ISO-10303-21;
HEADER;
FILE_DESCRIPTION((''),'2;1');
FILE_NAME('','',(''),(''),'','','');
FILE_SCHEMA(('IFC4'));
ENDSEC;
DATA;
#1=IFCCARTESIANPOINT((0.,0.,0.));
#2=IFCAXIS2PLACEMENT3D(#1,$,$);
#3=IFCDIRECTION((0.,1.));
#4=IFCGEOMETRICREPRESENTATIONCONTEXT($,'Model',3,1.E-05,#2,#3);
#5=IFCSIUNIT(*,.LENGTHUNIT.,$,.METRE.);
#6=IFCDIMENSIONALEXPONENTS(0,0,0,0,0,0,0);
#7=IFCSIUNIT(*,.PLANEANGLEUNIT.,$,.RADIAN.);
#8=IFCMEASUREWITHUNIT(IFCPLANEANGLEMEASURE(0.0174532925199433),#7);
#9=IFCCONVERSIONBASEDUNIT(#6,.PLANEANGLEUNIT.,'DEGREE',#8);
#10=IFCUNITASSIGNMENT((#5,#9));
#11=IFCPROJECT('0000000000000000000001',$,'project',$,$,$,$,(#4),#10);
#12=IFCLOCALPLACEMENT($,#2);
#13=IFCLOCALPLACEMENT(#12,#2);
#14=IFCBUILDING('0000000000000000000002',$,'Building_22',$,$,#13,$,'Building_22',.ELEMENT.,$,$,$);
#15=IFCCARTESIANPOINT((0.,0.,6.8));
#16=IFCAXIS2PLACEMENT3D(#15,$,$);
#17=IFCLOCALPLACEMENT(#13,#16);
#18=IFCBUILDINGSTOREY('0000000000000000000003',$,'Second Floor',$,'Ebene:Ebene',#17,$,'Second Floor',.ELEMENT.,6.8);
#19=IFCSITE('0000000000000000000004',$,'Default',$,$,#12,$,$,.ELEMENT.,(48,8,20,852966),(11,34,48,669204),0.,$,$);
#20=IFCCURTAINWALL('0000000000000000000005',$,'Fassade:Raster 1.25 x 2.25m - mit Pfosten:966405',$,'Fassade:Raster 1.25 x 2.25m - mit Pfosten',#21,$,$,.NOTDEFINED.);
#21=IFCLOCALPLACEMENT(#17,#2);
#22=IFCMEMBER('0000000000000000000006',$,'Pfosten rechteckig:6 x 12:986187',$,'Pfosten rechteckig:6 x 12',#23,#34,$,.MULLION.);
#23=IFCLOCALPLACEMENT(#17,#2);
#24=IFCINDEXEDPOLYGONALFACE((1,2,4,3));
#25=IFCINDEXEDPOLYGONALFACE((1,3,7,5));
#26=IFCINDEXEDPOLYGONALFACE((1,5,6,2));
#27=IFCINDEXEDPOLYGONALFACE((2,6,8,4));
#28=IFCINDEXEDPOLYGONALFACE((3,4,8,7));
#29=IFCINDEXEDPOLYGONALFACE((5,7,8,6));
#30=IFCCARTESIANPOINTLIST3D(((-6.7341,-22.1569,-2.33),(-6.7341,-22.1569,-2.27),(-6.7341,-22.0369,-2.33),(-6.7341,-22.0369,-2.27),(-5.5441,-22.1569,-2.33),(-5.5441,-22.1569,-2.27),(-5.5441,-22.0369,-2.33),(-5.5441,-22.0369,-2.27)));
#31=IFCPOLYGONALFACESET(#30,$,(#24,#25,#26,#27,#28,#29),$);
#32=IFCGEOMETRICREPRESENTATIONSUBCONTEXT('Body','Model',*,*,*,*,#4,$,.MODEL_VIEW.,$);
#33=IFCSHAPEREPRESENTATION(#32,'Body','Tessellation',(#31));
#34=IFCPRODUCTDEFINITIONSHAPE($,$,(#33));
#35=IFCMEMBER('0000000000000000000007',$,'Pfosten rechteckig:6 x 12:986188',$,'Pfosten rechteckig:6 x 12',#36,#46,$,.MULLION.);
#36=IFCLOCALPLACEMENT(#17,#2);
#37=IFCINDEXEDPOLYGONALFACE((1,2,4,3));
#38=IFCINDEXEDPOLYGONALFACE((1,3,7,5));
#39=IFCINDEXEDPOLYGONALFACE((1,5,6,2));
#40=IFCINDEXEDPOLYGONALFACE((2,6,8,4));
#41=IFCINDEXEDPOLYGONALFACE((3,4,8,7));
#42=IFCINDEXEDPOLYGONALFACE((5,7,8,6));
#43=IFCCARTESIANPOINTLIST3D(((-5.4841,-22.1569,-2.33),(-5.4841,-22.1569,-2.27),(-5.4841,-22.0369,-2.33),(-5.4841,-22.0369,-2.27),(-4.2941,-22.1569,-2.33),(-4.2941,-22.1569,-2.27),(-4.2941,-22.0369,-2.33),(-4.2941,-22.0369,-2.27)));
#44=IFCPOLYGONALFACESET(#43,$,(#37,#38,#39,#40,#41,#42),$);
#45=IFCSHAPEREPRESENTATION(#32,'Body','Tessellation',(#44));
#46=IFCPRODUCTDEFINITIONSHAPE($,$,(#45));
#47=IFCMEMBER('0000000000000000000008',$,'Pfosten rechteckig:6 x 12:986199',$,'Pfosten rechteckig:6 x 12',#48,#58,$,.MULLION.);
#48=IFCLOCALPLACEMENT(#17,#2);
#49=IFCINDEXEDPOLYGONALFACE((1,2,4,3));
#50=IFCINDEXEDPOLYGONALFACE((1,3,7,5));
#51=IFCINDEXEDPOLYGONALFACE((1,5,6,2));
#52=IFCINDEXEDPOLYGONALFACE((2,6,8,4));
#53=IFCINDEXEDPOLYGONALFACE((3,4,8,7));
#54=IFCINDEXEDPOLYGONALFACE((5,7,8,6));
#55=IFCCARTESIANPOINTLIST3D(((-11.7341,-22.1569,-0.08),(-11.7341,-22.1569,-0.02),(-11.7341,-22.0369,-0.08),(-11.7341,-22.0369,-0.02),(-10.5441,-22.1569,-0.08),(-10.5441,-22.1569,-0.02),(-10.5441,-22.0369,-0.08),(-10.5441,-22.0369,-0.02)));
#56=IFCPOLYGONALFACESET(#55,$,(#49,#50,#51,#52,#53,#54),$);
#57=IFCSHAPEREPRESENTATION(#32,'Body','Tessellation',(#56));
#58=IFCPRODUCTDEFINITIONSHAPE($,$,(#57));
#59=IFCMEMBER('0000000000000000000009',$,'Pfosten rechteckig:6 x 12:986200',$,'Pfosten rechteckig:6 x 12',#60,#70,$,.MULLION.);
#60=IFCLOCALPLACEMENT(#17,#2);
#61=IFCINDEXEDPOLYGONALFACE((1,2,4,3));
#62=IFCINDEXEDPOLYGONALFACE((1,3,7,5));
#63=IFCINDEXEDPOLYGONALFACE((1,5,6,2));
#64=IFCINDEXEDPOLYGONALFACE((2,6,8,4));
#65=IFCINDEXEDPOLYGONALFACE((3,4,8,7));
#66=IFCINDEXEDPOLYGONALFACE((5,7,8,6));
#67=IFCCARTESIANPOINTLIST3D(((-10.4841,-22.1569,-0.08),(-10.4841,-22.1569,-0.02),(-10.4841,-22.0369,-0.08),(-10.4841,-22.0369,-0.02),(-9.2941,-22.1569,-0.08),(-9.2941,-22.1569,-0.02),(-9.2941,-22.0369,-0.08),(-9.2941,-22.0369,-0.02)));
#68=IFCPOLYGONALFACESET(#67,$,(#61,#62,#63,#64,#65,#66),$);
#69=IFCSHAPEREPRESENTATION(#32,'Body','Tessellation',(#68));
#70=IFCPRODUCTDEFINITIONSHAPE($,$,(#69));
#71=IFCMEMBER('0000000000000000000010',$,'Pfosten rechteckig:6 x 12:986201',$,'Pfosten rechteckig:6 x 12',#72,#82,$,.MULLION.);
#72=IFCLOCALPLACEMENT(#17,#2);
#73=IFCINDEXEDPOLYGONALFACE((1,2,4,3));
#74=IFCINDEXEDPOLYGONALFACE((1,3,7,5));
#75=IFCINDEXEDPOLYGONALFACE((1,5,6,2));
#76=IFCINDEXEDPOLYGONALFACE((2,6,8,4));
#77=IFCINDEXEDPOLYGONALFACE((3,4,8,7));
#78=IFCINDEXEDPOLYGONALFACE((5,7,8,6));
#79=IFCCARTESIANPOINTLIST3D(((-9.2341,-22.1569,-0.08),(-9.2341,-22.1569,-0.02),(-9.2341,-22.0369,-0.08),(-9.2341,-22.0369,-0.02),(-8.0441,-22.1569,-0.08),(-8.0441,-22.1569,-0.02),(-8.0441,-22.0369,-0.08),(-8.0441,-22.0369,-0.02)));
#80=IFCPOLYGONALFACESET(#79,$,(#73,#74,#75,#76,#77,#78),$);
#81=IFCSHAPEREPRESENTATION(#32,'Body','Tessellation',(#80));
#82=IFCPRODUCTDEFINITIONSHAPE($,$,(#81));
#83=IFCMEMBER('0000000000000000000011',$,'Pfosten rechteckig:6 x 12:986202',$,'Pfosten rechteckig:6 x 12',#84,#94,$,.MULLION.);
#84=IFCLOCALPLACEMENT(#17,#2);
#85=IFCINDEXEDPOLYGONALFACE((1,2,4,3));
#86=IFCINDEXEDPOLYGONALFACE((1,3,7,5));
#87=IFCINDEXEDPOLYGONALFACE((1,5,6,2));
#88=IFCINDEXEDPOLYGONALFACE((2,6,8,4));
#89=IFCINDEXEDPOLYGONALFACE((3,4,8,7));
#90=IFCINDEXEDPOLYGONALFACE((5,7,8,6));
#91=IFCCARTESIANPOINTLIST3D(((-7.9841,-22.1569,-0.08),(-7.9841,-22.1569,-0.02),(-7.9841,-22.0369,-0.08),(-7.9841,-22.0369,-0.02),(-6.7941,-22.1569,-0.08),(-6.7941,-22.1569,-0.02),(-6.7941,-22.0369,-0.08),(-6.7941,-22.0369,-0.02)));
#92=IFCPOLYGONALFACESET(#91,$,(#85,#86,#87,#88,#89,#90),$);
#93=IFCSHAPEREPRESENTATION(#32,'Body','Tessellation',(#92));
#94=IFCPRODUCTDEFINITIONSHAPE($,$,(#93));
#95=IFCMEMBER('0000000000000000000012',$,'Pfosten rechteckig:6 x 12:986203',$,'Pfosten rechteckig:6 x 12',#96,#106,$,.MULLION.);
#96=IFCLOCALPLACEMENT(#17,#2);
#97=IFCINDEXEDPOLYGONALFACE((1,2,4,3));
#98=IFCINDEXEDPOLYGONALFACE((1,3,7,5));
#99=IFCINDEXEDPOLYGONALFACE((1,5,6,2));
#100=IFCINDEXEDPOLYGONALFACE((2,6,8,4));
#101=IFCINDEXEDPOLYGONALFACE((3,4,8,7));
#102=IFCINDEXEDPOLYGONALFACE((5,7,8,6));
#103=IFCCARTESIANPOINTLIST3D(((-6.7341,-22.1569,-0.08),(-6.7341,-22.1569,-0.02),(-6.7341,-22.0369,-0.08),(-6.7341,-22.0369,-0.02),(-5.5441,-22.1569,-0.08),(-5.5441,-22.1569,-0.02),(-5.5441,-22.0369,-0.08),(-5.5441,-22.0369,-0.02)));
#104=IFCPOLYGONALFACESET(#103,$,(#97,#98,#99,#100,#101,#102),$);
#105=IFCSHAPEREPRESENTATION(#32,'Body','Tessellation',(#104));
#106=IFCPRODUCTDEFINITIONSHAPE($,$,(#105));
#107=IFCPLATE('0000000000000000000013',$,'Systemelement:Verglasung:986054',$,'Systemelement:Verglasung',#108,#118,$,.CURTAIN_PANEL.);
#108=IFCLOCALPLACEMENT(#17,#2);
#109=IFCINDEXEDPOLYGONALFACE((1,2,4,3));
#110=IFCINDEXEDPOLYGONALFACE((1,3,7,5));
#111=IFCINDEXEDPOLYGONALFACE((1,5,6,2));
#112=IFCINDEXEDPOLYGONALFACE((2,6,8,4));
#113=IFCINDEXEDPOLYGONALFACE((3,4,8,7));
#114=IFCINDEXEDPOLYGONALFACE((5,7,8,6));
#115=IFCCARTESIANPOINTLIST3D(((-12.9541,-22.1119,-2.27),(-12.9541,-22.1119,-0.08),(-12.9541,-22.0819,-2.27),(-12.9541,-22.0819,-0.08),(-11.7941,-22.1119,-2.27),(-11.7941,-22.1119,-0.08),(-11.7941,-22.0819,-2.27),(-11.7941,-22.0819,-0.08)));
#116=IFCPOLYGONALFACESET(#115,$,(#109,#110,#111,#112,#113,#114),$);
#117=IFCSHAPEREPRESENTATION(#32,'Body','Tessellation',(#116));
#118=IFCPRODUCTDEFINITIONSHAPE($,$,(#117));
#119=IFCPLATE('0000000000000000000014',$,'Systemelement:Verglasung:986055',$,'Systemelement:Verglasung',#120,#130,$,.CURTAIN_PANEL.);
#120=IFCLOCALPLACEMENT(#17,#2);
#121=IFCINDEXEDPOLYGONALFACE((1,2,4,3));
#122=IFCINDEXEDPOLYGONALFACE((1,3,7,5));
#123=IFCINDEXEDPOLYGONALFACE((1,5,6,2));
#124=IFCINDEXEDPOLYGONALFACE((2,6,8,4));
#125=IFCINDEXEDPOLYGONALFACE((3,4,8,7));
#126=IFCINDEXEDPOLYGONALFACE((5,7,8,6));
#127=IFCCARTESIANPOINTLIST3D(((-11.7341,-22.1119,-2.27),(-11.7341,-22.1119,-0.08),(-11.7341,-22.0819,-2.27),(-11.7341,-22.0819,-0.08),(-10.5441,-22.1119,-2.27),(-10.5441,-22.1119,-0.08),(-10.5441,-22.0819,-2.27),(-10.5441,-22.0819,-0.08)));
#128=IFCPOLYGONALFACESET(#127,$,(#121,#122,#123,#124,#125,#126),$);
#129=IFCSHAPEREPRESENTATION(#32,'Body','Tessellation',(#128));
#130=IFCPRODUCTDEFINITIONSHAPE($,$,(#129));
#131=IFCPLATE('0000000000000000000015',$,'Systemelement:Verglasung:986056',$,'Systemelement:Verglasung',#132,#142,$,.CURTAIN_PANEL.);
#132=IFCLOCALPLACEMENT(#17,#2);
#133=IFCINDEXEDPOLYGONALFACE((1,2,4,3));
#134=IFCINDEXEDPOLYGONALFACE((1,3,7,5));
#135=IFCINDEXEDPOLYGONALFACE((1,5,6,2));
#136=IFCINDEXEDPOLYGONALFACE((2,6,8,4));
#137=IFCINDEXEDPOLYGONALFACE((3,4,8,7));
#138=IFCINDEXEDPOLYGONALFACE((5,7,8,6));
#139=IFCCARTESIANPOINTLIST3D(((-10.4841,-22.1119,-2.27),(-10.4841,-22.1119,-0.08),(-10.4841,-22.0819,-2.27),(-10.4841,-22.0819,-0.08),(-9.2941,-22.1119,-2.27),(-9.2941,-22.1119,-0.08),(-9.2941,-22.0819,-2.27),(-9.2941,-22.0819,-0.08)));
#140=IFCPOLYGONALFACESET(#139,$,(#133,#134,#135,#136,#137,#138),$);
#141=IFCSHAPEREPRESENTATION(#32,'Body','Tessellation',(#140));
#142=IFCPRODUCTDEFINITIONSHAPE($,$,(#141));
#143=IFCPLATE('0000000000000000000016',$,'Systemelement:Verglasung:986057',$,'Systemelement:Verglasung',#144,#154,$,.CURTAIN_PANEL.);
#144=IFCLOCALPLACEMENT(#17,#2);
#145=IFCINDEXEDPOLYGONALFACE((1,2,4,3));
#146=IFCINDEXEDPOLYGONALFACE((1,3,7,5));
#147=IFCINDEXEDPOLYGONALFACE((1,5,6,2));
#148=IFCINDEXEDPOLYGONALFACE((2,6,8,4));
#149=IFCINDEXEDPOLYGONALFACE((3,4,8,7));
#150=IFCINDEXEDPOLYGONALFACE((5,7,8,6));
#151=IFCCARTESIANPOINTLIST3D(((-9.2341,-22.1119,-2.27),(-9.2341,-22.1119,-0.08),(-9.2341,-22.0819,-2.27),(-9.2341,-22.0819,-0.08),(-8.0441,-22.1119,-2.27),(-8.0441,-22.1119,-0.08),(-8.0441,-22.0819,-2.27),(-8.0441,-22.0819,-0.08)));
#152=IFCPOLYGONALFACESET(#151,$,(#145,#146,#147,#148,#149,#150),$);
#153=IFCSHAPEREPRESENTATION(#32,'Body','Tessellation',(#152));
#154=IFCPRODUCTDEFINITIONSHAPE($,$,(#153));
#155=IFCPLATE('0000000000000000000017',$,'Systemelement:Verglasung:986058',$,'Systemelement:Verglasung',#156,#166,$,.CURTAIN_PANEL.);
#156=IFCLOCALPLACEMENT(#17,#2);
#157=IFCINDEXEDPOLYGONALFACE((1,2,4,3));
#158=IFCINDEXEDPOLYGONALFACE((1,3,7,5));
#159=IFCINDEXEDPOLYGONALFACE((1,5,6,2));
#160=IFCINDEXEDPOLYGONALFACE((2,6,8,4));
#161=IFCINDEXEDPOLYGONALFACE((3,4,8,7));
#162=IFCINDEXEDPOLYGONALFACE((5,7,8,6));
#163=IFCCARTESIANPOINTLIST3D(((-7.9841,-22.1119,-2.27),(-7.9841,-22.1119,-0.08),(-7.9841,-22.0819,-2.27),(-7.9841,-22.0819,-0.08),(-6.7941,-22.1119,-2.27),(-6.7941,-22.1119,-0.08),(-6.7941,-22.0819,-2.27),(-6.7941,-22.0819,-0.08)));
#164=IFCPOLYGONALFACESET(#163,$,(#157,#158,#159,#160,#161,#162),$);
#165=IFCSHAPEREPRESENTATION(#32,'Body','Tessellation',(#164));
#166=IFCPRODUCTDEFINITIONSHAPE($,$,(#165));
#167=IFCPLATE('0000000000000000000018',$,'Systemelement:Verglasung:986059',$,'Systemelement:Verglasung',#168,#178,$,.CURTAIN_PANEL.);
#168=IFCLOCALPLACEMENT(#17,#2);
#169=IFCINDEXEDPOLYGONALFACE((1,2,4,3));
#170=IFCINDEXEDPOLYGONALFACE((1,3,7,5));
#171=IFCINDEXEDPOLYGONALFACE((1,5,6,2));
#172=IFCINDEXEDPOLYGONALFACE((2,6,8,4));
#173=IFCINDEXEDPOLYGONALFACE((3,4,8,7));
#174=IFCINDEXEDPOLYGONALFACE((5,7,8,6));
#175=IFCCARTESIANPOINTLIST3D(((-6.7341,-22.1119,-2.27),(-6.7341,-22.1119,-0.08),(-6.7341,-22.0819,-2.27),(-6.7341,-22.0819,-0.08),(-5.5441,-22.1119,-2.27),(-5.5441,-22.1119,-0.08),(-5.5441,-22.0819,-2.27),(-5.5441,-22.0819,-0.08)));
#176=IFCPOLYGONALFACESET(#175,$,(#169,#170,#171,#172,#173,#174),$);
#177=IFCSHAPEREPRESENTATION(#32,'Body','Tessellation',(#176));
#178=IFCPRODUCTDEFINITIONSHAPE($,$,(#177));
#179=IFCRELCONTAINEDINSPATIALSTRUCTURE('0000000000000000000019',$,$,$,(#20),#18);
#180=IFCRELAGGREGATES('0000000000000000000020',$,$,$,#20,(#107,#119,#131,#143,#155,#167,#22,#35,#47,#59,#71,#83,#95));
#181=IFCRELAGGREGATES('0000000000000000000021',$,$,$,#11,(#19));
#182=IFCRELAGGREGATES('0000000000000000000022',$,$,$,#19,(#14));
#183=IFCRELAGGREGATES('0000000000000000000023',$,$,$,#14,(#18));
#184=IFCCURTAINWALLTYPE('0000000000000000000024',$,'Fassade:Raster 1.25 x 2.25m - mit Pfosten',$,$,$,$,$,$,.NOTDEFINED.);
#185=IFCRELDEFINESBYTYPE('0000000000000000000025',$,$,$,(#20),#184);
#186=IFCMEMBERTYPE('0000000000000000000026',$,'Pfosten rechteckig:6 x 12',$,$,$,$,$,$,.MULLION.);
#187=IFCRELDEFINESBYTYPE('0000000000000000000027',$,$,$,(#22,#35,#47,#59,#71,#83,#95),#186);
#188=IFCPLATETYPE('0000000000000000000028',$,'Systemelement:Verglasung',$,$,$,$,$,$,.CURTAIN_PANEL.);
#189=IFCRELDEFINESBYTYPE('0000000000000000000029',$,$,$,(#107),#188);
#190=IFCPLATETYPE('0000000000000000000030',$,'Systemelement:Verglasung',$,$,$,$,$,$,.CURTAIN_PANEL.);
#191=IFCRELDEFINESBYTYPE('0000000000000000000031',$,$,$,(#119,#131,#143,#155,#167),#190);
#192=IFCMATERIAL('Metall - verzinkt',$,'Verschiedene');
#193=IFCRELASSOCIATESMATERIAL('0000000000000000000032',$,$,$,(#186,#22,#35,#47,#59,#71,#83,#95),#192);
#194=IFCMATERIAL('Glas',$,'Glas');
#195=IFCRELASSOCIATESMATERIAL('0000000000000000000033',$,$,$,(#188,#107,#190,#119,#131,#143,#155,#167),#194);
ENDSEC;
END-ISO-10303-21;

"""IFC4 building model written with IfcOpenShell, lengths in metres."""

from ifc_helpers import new_model, entity, si_unit, converted_unit, direction, frame, origin, place, context, subcontext, project, spatial, indexed_curve, outline, extrude, source, transform, mapped, material, type_object, type_shapes, element, aggregate, save


model = new_model("IFC4")

# Units and contexts
model_context = context("Model", 3, precision=1e-05, world=origin(), true_north=direction((0.0, 1.0)))
body_context = subcontext(model_context, "Body", "Model", "MODEL_VIEW")
ifc_project = project(units=[si_unit("LENGTHUNIT", "METRE"), converted_unit("PLANEANGLEUNIT", "DEGREE", entity("IfcPlaneAngleMeasure", 0.0174532925199433), si_unit("PLANEANGLEUNIT", "RADIAN"), dimensions=[0, 0, 0, 0, 0, 0, 0])], contexts=[model_context])

# Site, building, storey
site_placement = place(None, origin())
site = spatial("IfcSite", under=ifc_project, at=site_placement, Name="Default", CompositionType="ELEMENT", RefLatitude=(48, 8, 20, 852966), RefLongitude=(11, 34, 48, 669204), RefElevation=0.0)
building_placement = place(site_placement, origin())
building = spatial("IfcBuilding", under=site, at=building_placement, Name="Building_22", LongName="Building_22", CompositionType="ELEMENT")
storey_placement = place(building_placement, frame((0.0, 0.0, 6.8)))
storey = spatial("IfcBuildingStorey", under=building, at=storey_placement, Name="Second Floor", ObjectType="Ebene:Ebene", LongName="Second Floor", CompositionType="ELEMENT", Elevation=6.8)

# Curtain wall, members, plates
curtain_wall_type = type_object("IfcCurtainWallType", Name="Fassade:Raster 1.25 x 2.25m - mit Pfosten", PredefinedType="NOTDEFINED")
curtain_wall_placement = place(storey_placement, frame((0.0, 0.0, -6.8)))
curtain_wall = element("IfcCurtainWall", 1, at=curtain_wall_placement, inside=storey, type_object=curtain_wall_type, Name="Fassade:Raster 1.25 x 2.25m - mit Pfosten:966405", ObjectType="Fassade:Raster 1.25 x 2.25m - mit Pfosten", PredefinedType="NOTDEFINED")
ifc_material_1 = material(Name="Metall - verzinkt", Category="Verschiedene")
member_type_1 = type_object("IfcMemberType", Name="Pfosten rechteckig:6 x 12", PredefinedType="MULLION", material=ifc_material_1)
shared_shape_1 = source(origin(), body_context, "Body", "SweptSolid", [
    extrude(outline(indexed_curve([(-0.03, -0.06), (0.03, -0.06), (0.03, 0.06), (-0.03, 0.06), (-0.03, -0.06)], self_intersect=False)), frame((0.0, 0.0, -1.19), z_axis=(0.0, 0.0, 1.0), x_axis=(-1.0, 0.0, 0.0)), (0.0, 0.0, 1.0), 1.19),
])
type_shapes(member_type_1, [shared_shape_1])
member_1_placement = place(curtain_wall_placement, frame((-5.5441, -22.0969, 4.5), z_axis=(1.0, 0.0, 0.0), x_axis=(0.0, 0.0, 1.0)))
member_1 = element("IfcMember", 2, at=member_1_placement, type_object=member_type_1, material=ifc_material_1, Name="Pfosten rechteckig:6 x 12:986187", ObjectType="Pfosten rechteckig:6 x 12", PredefinedType="MULLION", context=body_context, shape_type="MappedRepresentation", body=[
    mapped(shared_shape_1, transform((0.0, 0.0, 0.0), scale=1.0)),
])
member_2_placement = place(curtain_wall_placement, frame((-4.2941, -22.0969, 4.5), z_axis=(1.0, 0.0, 0.0), x_axis=(0.0, 0.0, 1.0)))
member_2 = element("IfcMember", 3, at=member_2_placement, type_object=member_type_1, material=ifc_material_1, Name="Pfosten rechteckig:6 x 12:986188", ObjectType="Pfosten rechteckig:6 x 12", PredefinedType="MULLION", context=body_context, shape_type="MappedRepresentation", body=[
    mapped(shared_shape_1, transform((0.0, 0.0, 0.0), scale=1.0)),
])
member_3_placement = place(curtain_wall_placement, frame((-10.5441, -22.0969, 6.75), z_axis=(1.0, 0.0, 0.0), x_axis=(0.0, 0.0, 1.0)))
member_3 = element("IfcMember", 4, at=member_3_placement, type_object=member_type_1, material=ifc_material_1, Name="Pfosten rechteckig:6 x 12:986199", ObjectType="Pfosten rechteckig:6 x 12", PredefinedType="MULLION", context=body_context, shape_type="MappedRepresentation", body=[
    mapped(shared_shape_1, transform((0.0, 0.0, 0.0), scale=1.0)),
])
member_4_placement = place(curtain_wall_placement, frame((-9.2941, -22.0969, 6.75), z_axis=(1.0, 0.0, 0.0), x_axis=(0.0, 0.0, 1.0)))
member_4 = element("IfcMember", 5, at=member_4_placement, type_object=member_type_1, material=ifc_material_1, Name="Pfosten rechteckig:6 x 12:986200", ObjectType="Pfosten rechteckig:6 x 12", PredefinedType="MULLION", context=body_context, shape_type="MappedRepresentation", body=[
    mapped(shared_shape_1, transform((0.0, 0.0, 0.0), scale=1.0)),
])
member_5_placement = place(curtain_wall_placement, frame((-8.0441, -22.0969, 6.75), z_axis=(1.0, 0.0, 0.0), x_axis=(0.0, 0.0, 1.0)))
member_5 = element("IfcMember", 6, at=member_5_placement, type_object=member_type_1, material=ifc_material_1, Name="Pfosten rechteckig:6 x 12:986201", ObjectType="Pfosten rechteckig:6 x 12", PredefinedType="MULLION", context=body_context, shape_type="MappedRepresentation", body=[
    mapped(shared_shape_1, transform((0.0, 0.0, 0.0), scale=1.0)),
])
member_6_placement = place(curtain_wall_placement, frame((-6.7941, -22.0969, 6.75), z_axis=(1.0, 0.0, 0.0), x_axis=(0.0, 0.0, 1.0)))
member_6 = element("IfcMember", 7, at=member_6_placement, type_object=member_type_1, material=ifc_material_1, Name="Pfosten rechteckig:6 x 12:986202", ObjectType="Pfosten rechteckig:6 x 12", PredefinedType="MULLION", context=body_context, shape_type="MappedRepresentation", body=[
    mapped(shared_shape_1, transform((0.0, 0.0, 0.0), scale=1.0)),
])
member_7_placement = place(curtain_wall_placement, frame((-5.5441, -22.0969, 6.75), z_axis=(1.0, 0.0, 0.0), x_axis=(0.0, 0.0, 1.0)))
member_7 = element("IfcMember", 8, at=member_7_placement, type_object=member_type_1, material=ifc_material_1, Name="Pfosten rechteckig:6 x 12:986203", ObjectType="Pfosten rechteckig:6 x 12", PredefinedType="MULLION", context=body_context, shape_type="MappedRepresentation", body=[
    mapped(shared_shape_1, transform((0.0, 0.0, 0.0), scale=1.0)),
])
ifc_material_2 = material(Name="Glas", Category="Glas")
plate_type_1 = type_object("IfcPlateType", Name="Systemelement:Verglasung", PredefinedType="CURTAIN_PANEL", material=ifc_material_2)
shared_shape_2 = source(origin(), body_context, "Body", "SweptSolid", [
    extrude(outline(indexed_curve([(-0.015, -0.58), (0.015, -0.58), (0.015, 0.58), (-0.015, 0.58), (-0.015, -0.58)], self_intersect=False)), frame((0.0, 0.0, 0.0), z_axis=(0.0, 0.0, 1.0), x_axis=(0.0, 1.0, 0.0)), (0.0, 0.0, 1.0), 2.19),
])
type_shapes(plate_type_1, [shared_shape_2])
plate_1_placement = place(curtain_wall_placement, frame((-12.3741, -22.0969, 4.53)))
plate_1 = element("IfcPlate", 9, at=plate_1_placement, type_object=plate_type_1, material=ifc_material_2, Name="Systemelement:Verglasung:986054", ObjectType="Systemelement:Verglasung", PredefinedType="CURTAIN_PANEL", context=body_context, shape_type="MappedRepresentation", body=[
    mapped(shared_shape_2, transform((0.0, 0.0, 0.0), scale=1.0)),
])
plate_type_2 = type_object("IfcPlateType", Name="Systemelement:Verglasung", PredefinedType="CURTAIN_PANEL", material=ifc_material_2)
shared_shape_3 = source(origin(), body_context, "Body", "SweptSolid", [
    extrude(outline(indexed_curve([(-0.015, -0.595), (0.015, -0.595), (0.015, 0.595), (-0.015, 0.595), (-0.015, -0.595)], self_intersect=False)), frame((0.0, 0.0, 0.0), z_axis=(0.0, 0.0, 1.0), x_axis=(0.0, 1.0, 0.0)), (0.0, 0.0, 1.0), 2.19),
])
type_shapes(plate_type_2, [shared_shape_3])
plate_2_placement = place(curtain_wall_placement, frame((-11.1391, -22.0969, 4.53)))
plate_2 = element("IfcPlate", 10, at=plate_2_placement, type_object=plate_type_2, material=ifc_material_2, Name="Systemelement:Verglasung:986055", ObjectType="Systemelement:Verglasung", PredefinedType="CURTAIN_PANEL", context=body_context, shape_type="MappedRepresentation", body=[
    mapped(shared_shape_3, transform((0.0, 0.0, 0.0), scale=1.0)),
])
plate_3_placement = place(curtain_wall_placement, frame((-9.8891, -22.0969, 4.53)))
plate_3 = element("IfcPlate", 11, at=plate_3_placement, type_object=plate_type_2, material=ifc_material_2, Name="Systemelement:Verglasung:986056", ObjectType="Systemelement:Verglasung", PredefinedType="CURTAIN_PANEL", context=body_context, shape_type="MappedRepresentation", body=[
    mapped(shared_shape_3, transform((0.0, 0.0, 0.0), scale=1.0)),
])
plate_4_placement = place(curtain_wall_placement, frame((-8.6391, -22.0969, 4.53)))
plate_4 = element("IfcPlate", 12, at=plate_4_placement, type_object=plate_type_2, material=ifc_material_2, Name="Systemelement:Verglasung:986057", ObjectType="Systemelement:Verglasung", PredefinedType="CURTAIN_PANEL", context=body_context, shape_type="MappedRepresentation", body=[
    mapped(shared_shape_3, transform((0.0, 0.0, 0.0), scale=1.0)),
])
plate_5_placement = place(curtain_wall_placement, frame((-7.3891, -22.0969, 4.53)))
plate_5 = element("IfcPlate", 13, at=plate_5_placement, type_object=plate_type_2, material=ifc_material_2, Name="Systemelement:Verglasung:986058", ObjectType="Systemelement:Verglasung", PredefinedType="CURTAIN_PANEL", context=body_context, shape_type="MappedRepresentation", body=[
    mapped(shared_shape_3, transform((0.0, 0.0, 0.0), scale=1.0)),
])
plate_6_placement = place(curtain_wall_placement, frame((-6.1391, -22.0969, 4.53)))
plate_6 = element("IfcPlate", 14, at=plate_6_placement, type_object=plate_type_2, material=ifc_material_2, Name="Systemelement:Verglasung:986059", ObjectType="Systemelement:Verglasung", PredefinedType="CURTAIN_PANEL", context=body_context, shape_type="MappedRepresentation", body=[
    mapped(shared_shape_3, transform((0.0, 0.0, 0.0), scale=1.0)),
])
aggregate(curtain_wall, [plate_1, plate_2, plate_3, plate_4, plate_5, plate_6, member_1, member_2, member_3, member_4, member_5, member_6, member_7])

save(model, "model.ifc")
